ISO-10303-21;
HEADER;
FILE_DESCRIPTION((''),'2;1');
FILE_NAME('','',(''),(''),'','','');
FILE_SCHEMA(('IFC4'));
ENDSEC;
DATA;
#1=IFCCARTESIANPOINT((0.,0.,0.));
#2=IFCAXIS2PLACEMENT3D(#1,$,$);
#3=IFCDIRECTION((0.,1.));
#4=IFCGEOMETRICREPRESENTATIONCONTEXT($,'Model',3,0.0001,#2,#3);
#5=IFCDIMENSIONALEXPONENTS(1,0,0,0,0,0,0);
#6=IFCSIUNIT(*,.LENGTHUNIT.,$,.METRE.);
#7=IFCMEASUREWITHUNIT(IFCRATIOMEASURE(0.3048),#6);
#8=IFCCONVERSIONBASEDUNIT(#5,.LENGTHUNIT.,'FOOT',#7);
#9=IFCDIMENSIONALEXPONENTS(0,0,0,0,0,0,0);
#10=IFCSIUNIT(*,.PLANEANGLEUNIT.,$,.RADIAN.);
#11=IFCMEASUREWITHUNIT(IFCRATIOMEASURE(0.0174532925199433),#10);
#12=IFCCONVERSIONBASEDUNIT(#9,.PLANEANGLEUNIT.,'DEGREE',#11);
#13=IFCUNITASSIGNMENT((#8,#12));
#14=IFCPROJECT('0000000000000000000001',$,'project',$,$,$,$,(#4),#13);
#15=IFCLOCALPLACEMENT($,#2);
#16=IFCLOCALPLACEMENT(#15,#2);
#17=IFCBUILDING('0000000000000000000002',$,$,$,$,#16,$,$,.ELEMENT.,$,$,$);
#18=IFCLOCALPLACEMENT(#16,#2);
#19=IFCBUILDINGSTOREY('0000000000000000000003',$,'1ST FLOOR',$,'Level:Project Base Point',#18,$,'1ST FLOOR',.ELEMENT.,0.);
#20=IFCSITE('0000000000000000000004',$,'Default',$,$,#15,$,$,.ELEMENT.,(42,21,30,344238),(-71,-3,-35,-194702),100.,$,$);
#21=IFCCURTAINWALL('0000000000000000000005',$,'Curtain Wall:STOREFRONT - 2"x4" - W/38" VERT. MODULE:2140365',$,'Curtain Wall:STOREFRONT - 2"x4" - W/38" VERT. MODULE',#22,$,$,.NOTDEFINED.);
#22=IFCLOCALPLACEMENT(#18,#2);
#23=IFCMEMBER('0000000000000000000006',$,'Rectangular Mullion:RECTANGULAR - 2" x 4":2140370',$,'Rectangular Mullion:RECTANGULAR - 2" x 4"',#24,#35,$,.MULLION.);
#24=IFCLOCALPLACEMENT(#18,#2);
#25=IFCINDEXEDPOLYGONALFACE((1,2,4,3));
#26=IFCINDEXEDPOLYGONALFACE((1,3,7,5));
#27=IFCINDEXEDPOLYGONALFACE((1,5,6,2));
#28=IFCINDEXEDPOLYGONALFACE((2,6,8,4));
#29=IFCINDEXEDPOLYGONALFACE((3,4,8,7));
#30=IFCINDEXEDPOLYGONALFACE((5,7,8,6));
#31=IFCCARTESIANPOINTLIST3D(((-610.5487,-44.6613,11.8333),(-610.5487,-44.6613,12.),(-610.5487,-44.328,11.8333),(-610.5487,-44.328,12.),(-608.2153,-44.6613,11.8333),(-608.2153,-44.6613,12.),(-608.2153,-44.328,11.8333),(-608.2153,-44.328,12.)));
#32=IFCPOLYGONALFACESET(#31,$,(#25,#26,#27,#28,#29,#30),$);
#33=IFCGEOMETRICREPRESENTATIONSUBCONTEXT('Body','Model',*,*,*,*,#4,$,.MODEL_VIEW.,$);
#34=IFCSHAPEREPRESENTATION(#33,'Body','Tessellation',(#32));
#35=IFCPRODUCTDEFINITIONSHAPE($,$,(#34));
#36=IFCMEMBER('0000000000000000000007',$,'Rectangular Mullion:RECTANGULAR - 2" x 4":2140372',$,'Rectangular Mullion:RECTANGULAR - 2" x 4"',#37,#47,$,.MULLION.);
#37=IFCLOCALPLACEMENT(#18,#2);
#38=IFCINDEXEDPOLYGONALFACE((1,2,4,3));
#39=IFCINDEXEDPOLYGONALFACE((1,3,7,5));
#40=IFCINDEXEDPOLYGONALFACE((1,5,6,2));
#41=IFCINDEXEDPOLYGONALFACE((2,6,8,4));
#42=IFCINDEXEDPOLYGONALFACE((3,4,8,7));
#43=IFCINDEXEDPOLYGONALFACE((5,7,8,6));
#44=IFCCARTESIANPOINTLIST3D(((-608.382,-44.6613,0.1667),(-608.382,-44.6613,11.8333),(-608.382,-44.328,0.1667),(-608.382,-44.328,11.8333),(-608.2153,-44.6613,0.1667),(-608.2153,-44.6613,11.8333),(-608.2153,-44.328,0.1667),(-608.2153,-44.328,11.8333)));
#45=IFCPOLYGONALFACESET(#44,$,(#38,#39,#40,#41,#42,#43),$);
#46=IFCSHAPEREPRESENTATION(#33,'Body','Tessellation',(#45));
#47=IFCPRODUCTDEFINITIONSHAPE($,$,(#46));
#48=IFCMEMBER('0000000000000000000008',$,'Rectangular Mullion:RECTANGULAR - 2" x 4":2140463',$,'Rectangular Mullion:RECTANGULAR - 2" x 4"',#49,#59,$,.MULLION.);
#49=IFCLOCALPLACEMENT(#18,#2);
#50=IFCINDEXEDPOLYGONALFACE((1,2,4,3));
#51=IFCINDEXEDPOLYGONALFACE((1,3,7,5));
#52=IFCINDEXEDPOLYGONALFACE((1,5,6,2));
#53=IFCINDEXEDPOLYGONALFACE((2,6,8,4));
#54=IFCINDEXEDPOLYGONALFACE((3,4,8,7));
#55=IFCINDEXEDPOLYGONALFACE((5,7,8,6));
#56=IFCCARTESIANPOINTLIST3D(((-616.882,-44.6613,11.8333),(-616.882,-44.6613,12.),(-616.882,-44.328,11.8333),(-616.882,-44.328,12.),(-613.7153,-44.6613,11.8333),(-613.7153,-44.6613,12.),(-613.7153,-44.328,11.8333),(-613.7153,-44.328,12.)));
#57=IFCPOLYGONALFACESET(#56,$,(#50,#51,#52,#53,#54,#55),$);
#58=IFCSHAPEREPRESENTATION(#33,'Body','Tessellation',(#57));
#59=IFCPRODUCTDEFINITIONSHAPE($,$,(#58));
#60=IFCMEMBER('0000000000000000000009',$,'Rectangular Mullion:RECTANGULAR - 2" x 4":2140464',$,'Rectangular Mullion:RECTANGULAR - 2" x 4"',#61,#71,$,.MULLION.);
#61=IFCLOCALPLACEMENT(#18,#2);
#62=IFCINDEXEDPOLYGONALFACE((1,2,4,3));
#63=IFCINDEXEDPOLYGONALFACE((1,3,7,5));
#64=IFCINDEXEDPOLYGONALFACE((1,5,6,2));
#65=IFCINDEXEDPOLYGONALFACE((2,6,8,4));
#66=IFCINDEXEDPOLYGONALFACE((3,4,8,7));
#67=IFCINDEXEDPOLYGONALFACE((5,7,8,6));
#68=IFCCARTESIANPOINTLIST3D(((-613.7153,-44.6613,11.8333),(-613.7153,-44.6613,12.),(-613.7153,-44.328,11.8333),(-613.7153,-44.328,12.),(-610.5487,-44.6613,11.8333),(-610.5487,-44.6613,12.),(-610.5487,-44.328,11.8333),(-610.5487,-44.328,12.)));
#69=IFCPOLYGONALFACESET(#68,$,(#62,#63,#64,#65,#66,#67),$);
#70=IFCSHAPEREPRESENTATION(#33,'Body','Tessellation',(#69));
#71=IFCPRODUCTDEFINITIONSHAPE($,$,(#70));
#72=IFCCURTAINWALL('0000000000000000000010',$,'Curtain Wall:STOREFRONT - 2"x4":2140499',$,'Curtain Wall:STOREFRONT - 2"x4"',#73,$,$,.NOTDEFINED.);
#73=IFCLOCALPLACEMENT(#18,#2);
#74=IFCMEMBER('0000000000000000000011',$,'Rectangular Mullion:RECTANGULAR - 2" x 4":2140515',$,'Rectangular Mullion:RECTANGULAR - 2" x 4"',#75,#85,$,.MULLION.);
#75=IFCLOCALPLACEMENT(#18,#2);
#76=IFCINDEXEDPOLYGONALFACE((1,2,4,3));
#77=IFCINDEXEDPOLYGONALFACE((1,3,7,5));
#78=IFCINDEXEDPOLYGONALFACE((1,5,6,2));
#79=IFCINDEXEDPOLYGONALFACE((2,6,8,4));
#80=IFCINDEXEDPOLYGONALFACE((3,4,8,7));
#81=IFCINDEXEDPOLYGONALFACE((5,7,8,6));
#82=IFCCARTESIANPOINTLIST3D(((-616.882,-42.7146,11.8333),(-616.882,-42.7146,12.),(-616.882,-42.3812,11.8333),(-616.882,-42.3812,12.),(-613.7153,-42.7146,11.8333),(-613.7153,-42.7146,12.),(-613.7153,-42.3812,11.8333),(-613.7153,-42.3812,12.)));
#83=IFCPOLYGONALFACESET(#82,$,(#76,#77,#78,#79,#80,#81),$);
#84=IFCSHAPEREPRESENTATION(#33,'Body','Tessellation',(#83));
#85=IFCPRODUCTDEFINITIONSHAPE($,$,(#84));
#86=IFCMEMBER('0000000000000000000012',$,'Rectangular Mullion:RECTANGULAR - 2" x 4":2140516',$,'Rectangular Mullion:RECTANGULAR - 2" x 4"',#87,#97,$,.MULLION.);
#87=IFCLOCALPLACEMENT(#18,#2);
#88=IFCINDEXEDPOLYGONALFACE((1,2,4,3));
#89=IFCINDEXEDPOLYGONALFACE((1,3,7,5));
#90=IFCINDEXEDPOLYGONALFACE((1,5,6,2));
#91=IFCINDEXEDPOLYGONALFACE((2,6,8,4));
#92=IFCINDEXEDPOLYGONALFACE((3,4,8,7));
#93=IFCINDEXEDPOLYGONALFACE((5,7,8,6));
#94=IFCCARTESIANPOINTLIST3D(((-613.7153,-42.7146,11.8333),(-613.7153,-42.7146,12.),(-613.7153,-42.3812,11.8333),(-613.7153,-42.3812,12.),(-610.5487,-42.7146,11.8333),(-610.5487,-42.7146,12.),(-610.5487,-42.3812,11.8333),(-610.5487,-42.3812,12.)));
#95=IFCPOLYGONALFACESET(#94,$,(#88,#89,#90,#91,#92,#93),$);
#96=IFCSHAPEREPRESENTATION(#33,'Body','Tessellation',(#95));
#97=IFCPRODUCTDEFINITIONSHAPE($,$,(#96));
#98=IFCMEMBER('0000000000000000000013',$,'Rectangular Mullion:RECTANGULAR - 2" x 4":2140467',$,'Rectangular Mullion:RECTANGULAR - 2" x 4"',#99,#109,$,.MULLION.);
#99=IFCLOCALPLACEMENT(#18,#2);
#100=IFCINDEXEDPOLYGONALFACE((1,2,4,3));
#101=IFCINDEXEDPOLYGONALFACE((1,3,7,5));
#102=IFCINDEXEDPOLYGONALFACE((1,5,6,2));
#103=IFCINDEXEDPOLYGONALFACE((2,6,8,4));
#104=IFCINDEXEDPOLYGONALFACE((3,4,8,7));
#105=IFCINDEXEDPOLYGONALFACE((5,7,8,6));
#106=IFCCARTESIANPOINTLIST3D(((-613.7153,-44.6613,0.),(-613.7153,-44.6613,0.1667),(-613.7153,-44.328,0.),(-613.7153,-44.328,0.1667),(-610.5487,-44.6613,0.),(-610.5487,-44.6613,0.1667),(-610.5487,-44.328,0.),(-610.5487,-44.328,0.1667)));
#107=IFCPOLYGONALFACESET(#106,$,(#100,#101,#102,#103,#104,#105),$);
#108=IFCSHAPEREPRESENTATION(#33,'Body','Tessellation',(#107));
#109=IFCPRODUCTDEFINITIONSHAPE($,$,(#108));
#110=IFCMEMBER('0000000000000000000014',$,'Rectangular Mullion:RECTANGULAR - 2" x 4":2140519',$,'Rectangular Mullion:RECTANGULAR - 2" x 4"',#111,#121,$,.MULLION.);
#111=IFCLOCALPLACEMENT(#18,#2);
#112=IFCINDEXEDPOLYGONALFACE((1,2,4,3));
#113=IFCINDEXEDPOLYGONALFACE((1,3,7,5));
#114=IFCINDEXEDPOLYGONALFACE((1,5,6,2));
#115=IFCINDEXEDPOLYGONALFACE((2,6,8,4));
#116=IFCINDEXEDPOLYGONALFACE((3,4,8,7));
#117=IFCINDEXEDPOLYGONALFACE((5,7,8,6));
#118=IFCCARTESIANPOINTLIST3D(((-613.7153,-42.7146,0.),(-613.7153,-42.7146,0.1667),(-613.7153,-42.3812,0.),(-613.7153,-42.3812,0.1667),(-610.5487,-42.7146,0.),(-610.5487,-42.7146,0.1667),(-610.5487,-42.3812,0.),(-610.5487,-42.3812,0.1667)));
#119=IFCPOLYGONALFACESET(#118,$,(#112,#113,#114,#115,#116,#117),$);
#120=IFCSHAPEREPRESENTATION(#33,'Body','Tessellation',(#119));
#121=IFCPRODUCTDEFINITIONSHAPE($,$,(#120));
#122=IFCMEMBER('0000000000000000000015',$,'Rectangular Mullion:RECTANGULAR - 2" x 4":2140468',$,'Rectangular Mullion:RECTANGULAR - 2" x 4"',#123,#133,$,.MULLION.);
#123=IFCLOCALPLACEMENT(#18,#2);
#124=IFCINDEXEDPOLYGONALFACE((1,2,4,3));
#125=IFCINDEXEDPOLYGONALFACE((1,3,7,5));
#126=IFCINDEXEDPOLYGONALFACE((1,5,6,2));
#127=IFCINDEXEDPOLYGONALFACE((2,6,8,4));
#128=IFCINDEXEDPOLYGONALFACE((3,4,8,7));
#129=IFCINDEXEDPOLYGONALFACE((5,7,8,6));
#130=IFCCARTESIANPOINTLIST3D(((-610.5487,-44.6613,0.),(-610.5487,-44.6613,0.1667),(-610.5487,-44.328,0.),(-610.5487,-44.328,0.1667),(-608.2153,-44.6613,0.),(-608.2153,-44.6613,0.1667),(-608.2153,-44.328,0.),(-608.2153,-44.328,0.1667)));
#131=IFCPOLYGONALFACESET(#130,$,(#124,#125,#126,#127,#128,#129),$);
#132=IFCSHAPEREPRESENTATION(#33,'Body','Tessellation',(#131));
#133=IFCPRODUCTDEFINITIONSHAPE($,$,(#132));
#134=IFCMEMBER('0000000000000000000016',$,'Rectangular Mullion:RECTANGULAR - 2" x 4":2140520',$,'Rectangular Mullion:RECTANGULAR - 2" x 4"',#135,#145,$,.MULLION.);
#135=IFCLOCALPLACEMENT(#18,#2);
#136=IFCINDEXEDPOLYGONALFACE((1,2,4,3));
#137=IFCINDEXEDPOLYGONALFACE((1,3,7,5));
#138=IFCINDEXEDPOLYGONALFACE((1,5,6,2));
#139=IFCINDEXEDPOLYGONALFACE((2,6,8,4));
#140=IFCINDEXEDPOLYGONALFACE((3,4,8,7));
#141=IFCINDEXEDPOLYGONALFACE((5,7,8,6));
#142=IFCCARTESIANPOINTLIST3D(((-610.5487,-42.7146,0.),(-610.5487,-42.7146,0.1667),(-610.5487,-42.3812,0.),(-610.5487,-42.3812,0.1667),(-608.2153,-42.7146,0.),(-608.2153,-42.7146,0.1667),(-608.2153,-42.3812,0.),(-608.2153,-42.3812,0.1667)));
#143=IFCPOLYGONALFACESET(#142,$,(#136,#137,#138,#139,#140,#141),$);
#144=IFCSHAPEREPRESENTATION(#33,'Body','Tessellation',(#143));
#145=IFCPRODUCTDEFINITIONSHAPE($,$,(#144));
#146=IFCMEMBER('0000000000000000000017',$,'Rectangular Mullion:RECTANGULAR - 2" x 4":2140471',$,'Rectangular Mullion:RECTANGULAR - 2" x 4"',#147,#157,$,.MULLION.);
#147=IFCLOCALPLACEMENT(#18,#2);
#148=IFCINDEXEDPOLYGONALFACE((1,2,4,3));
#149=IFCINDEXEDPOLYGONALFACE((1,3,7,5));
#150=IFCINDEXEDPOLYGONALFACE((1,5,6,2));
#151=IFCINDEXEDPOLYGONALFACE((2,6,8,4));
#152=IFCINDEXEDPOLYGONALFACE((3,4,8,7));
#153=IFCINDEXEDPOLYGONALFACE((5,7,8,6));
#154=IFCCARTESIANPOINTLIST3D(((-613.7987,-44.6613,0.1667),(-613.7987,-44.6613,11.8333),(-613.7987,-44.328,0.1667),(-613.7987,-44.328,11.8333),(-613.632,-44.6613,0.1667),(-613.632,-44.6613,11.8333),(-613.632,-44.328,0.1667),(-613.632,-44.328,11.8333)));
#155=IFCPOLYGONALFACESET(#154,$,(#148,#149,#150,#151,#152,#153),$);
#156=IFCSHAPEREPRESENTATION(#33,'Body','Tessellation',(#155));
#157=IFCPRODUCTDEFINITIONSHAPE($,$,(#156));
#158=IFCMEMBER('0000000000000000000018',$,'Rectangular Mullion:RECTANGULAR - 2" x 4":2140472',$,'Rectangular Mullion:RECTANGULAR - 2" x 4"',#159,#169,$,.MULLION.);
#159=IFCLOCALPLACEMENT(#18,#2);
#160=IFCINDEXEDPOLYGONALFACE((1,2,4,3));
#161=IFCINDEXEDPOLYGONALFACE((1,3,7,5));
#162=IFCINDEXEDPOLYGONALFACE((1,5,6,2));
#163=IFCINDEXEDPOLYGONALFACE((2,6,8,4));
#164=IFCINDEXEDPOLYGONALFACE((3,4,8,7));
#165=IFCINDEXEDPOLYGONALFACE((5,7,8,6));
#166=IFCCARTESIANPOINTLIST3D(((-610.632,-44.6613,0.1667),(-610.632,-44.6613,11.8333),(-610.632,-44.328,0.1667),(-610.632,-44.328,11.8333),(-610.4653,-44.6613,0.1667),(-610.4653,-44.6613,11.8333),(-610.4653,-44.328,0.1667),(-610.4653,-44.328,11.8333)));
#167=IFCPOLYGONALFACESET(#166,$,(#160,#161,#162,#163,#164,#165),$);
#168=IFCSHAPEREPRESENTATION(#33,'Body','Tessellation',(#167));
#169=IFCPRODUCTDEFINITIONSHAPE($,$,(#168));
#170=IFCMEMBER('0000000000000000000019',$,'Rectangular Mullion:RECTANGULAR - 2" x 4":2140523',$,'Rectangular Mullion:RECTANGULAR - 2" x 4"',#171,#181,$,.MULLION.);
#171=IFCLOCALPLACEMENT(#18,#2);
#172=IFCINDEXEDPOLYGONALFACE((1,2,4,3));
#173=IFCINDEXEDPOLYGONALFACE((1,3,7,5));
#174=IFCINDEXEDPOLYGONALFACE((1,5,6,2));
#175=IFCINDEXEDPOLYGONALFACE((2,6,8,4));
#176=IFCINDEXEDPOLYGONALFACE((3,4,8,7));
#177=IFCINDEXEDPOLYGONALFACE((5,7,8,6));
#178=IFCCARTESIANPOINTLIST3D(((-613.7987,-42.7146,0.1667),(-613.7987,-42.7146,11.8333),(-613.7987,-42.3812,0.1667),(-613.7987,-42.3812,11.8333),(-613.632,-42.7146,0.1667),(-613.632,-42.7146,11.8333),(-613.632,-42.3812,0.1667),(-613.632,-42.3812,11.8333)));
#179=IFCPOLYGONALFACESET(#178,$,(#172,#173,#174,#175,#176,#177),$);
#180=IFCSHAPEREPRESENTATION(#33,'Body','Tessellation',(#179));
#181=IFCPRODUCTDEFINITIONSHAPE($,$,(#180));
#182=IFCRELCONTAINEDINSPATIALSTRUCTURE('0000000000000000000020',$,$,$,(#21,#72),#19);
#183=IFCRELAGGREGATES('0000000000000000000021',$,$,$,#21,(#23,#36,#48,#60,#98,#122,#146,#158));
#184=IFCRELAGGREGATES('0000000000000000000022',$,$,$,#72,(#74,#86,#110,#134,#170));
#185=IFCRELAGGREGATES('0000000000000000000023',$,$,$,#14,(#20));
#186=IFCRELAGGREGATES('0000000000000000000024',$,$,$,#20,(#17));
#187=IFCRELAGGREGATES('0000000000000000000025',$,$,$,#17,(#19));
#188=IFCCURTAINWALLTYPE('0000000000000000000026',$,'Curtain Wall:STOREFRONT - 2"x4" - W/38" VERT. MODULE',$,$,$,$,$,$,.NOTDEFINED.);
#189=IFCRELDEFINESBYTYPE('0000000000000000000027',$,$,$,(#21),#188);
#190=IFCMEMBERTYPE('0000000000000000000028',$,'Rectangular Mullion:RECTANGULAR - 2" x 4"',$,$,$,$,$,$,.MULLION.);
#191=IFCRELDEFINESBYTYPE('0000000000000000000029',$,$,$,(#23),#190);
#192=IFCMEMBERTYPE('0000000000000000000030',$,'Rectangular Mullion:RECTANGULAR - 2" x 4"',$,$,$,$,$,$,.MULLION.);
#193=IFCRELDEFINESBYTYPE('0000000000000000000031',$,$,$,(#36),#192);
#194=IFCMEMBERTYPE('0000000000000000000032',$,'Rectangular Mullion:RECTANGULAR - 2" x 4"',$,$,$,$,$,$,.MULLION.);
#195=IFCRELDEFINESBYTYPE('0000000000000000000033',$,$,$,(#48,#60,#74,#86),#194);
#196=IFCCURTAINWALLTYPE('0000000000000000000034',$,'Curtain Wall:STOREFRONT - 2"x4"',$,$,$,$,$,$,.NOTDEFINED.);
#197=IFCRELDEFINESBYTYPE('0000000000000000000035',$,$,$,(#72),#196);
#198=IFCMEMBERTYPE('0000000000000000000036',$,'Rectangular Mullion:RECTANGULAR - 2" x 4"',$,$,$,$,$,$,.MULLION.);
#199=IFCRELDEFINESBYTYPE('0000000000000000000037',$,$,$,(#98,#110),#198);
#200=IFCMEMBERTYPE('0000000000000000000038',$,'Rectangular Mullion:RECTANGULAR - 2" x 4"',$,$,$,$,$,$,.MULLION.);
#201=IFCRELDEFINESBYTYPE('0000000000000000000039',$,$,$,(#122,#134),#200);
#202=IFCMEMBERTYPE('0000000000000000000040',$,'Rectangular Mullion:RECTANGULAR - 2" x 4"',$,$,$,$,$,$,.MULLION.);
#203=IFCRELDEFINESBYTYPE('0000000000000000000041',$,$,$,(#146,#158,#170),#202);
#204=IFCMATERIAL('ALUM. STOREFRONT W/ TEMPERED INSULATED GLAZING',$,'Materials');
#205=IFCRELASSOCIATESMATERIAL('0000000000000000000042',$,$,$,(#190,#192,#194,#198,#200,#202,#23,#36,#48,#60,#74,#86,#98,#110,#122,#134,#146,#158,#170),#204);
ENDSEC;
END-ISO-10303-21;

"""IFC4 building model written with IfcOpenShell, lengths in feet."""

from ifc_helpers import new_model, entity, si_unit, converted_unit, direction, frame, origin, origin_2d_with_axis, place, context, subcontext, project, spatial, rectangle, extrude, source, transform, mapped, material, material_profile, profile_set, profile_usage, type_object, type_shapes, element, aggregate, save


model = new_model("IFC4")

# Units and contexts
model_context = context("Model", 3, precision=0.0001, world=origin(), true_north=direction((0.0, 1.0)))
body_context = subcontext(model_context, "Body", "Model", "MODEL_VIEW")
ifc_project = project(units=[converted_unit("LENGTHUNIT", "FOOT", entity("IfcRatioMeasure", 0.3048), si_unit("LENGTHUNIT", "METRE"), dimensions=[1, 0, 0, 0, 0, 0, 0]), converted_unit("PLANEANGLEUNIT", "DEGREE", entity("IfcRatioMeasure", 0.0174532925199433), si_unit("PLANEANGLEUNIT", "RADIAN"), dimensions=[0, 0, 0, 0, 0, 0, 0])], contexts=[model_context])

# Site, building, storey
site_placement = place(None, origin())
site = spatial("IfcSite", under=ifc_project, at=site_placement, Name="Default", CompositionType="ELEMENT", RefLatitude=(42, 21, 30, 344238), RefLongitude=(-71, -3, -35, -194702), RefElevation=100.0)
building_placement = place(site_placement, origin())
building = spatial("IfcBuilding", under=site, at=building_placement, CompositionType="ELEMENT")
storey_placement = place(building_placement, origin())
storey = spatial("IfcBuildingStorey", under=building, at=storey_placement, Name="1ST FLOOR", ObjectType="Level:Project Base Point", LongName="1ST FLOOR", CompositionType="ELEMENT", Elevation=0.0)

# Curtain walls, members
curtain_wall_type_1 = type_object("IfcCurtainWallType", Name="Curtain Wall:STOREFRONT - 2\"x4\" - W/38\" VERT. MODULE", PredefinedType="NOTDEFINED")
curtain_wall_1_placement = place(storey_placement, origin())
curtain_wall_1 = element("IfcCurtainWall", 1, at=curtain_wall_1_placement, inside=storey, type_object=curtain_wall_type_1, Name="Curtain Wall:STOREFRONT - 2\"x4\" - W/38\" VERT. MODULE:2140365", ObjectType="Curtain Wall:STOREFRONT - 2\"x4\" - W/38\" VERT. MODULE", PredefinedType="NOTDEFINED")
ifc_material_1 = material(Name="ALUM. STOREFRONT W/ TEMPERED INSULATED GLAZING", Category="Materials")
ifc_material_profile_1 = material_profile(ifc_material_1, rectangle(XDim=0.3333, YDim=0.1667, at=origin_2d_with_axis()), Name="RECTANGULAR - 2\" x 4\"")
ifc_profile_set_1 = profile_set([ifc_material_profile_1], Name="RECTANGULAR - 2\" x 4\"")
ifc_profile_usage_1 = profile_usage(ifc_profile_set_1)
member_type_1 = type_object("IfcMemberType", Name="Rectangular Mullion:RECTANGULAR - 2\" x 4\"", PredefinedType="MULLION", material=ifc_profile_set_1)
shared_shape_1 = source(origin(), body_context, "Body", "SweptSolid", [
    extrude(rectangle(XDim=0.3333, YDim=0.1667, at=origin_2d_with_axis()), frame((-0.0833, 0.0, -2.3333), z_axis=(0.0, 0.0, 1.0), x_axis=(0.0, -1.0, 0.0)), (0.0, 0.0, 1.0), 2.3333),
])
type_shapes(member_type_1, [shared_shape_1])
member_1_placement = place(storey_placement, frame((-608.2153, -44.4946, 12.0), z_axis=(1.0, 0.0, 0.0), x_axis=(0.0, 0.0, 1.0)))
member_1 = element("IfcMember", 2, at=member_1_placement, type_object=member_type_1, material=ifc_profile_usage_1, Name="Rectangular Mullion:RECTANGULAR - 2\" x 4\":2140370", ObjectType="Rectangular Mullion:RECTANGULAR - 2\" x 4\"", PredefinedType="MULLION", context=body_context, shape_type="MappedRepresentation", body=[
    mapped(shared_shape_1, transform((0.0, 0.0, 0.0), scale=1.0)),
])
ifc_profile_usage_2 = profile_usage(ifc_profile_set_1)
member_type_2 = type_object("IfcMemberType", Name="Rectangular Mullion:RECTANGULAR - 2\" x 4\"", PredefinedType="MULLION", material=ifc_profile_set_1)
shared_shape_2 = source(origin(), body_context, "Body", "SweptSolid", [
    extrude(rectangle(XDim=0.3333, YDim=0.1667, at=origin_2d_with_axis()), frame((-0.0833, 0.0, -11.6667), z_axis=(0.0, 0.0, 1.0), x_axis=(0.0, -1.0, 0.0)), (0.0, 0.0, 1.0), 11.6667),
])
type_shapes(member_type_2, [shared_shape_2])
member_2_placement = place(storey_placement, frame((-608.2153, -44.4946, 0.1667), z_axis=(0.0, 0.0, -1.0), x_axis=(1.0, 0.0, 0.0)))
member_2 = element("IfcMember", 3, at=member_2_placement, type_object=member_type_2, material=ifc_profile_usage_2, Name="Rectangular Mullion:RECTANGULAR - 2\" x 4\":2140372", ObjectType="Rectangular Mullion:RECTANGULAR - 2\" x 4\"", PredefinedType="MULLION", context=body_context, shape_type="MappedRepresentation", body=[
    mapped(shared_shape_2, transform((0.0, 0.0, 0.0), scale=1.0)),
])
ifc_profile_usage_3 = profile_usage(ifc_profile_set_1)
member_type_3 = type_object("IfcMemberType", Name="Rectangular Mullion:RECTANGULAR - 2\" x 4\"", PredefinedType="MULLION", material=ifc_profile_set_1)
shared_shape_3 = source(origin(), body_context, "Body", "SweptSolid", [
    extrude(rectangle(XDim=0.3333, YDim=0.1667, at=origin_2d_with_axis()), frame((-0.0833, 0.0, -3.1667), z_axis=(0.0, 0.0, 1.0), x_axis=(0.0, -1.0, 0.0)), (0.0, 0.0, 1.0), 3.1667),
])
type_shapes(member_type_3, [shared_shape_3])
member_3_placement = place(storey_placement, frame((-613.7153, -44.4946, 12.0), z_axis=(1.0, 0.0, 0.0), x_axis=(0.0, 0.0, 1.0)))
member_3 = element("IfcMember", 4, at=member_3_placement, type_object=member_type_3, material=ifc_profile_usage_3, Name="Rectangular Mullion:RECTANGULAR - 2\" x 4\":2140463", ObjectType="Rectangular Mullion:RECTANGULAR - 2\" x 4\"", PredefinedType="MULLION", context=body_context, shape_type="MappedRepresentation", body=[
    mapped(shared_shape_3, transform((0.0, 0.0, 0.0), scale=1.0)),
])
ifc_profile_usage_4 = profile_usage(ifc_profile_set_1)
member_4_placement = place(storey_placement, frame((-610.5487, -44.4946, 12.0), z_axis=(1.0, 0.0, 0.0), x_axis=(0.0, 0.0, 1.0)))
member_4 = element("IfcMember", 5, at=member_4_placement, type_object=member_type_3, material=ifc_profile_usage_4, Name="Rectangular Mullion:RECTANGULAR - 2\" x 4\":2140464", ObjectType="Rectangular Mullion:RECTANGULAR - 2\" x 4\"", PredefinedType="MULLION", context=body_context, shape_type="MappedRepresentation", body=[
    mapped(shared_shape_3, transform((0.0, 0.0, 0.0), scale=1.0)),
])
curtain_wall_type_2 = type_object("IfcCurtainWallType", Name="Curtain Wall:STOREFRONT - 2\"x4\"", PredefinedType="NOTDEFINED")
curtain_wall_2_placement = place(storey_placement, origin())
curtain_wall_2 = element("IfcCurtainWall", 6, at=curtain_wall_2_placement, inside=storey, type_object=curtain_wall_type_2, Name="Curtain Wall:STOREFRONT - 2\"x4\":2140499", ObjectType="Curtain Wall:STOREFRONT - 2\"x4\"", PredefinedType="NOTDEFINED")
ifc_profile_usage_5 = profile_usage(ifc_profile_set_1)
member_5_placement = place(storey_placement, frame((-613.7153, -42.5479, 12.0), z_axis=(1.0, 0.0, 0.0), x_axis=(0.0, 0.0, 1.0)))
member_5 = element("IfcMember", 7, at=member_5_placement, type_object=member_type_3, material=ifc_profile_usage_5, Name="Rectangular Mullion:RECTANGULAR - 2\" x 4\":2140515", ObjectType="Rectangular Mullion:RECTANGULAR - 2\" x 4\"", PredefinedType="MULLION", context=body_context, shape_type="MappedRepresentation", body=[
    mapped(shared_shape_3, transform((0.0, 0.0, 0.0), scale=1.0)),
])
ifc_profile_usage_6 = profile_usage(ifc_profile_set_1)
member_6_placement = place(storey_placement, frame((-610.5487, -42.5479, 12.0), z_axis=(1.0, 0.0, 0.0), x_axis=(0.0, 0.0, 1.0)))
member_6 = element("IfcMember", 8, at=member_6_placement, type_object=member_type_3, material=ifc_profile_usage_6, Name="Rectangular Mullion:RECTANGULAR - 2\" x 4\":2140516", ObjectType="Rectangular Mullion:RECTANGULAR - 2\" x 4\"", PredefinedType="MULLION", context=body_context, shape_type="MappedRepresentation", body=[
    mapped(shared_shape_3, transform((0.0, 0.0, 0.0), scale=1.0)),
])

# Members
ifc_profile_usage_7 = profile_usage(ifc_profile_set_1)
member_type_4 = type_object("IfcMemberType", Name="Rectangular Mullion:RECTANGULAR - 2\" x 4\"", PredefinedType="MULLION", material=ifc_profile_set_1)
shared_shape_4 = source(origin(), body_context, "Body", "SweptSolid", [
    extrude(rectangle(XDim=0.3333, YDim=0.1667, at=origin_2d_with_axis()), frame((-0.0833, 0.0, -3.1667), z_axis=(0.0, 0.0, 1.0), x_axis=(0.0, -1.0, 0.0)), (0.0, 0.0, 1.0), 3.1667),
])
type_shapes(member_type_4, [shared_shape_4])
member_7_placement = place(storey_placement, frame((-613.7153, -44.4946, 0.0), z_axis=(-1.0, 0.0, 0.0), x_axis=(0.0, 0.0, -1.0)))
member_7 = element("IfcMember", 9, at=member_7_placement, type_object=member_type_4, material=ifc_profile_usage_7, Name="Rectangular Mullion:RECTANGULAR - 2\" x 4\":2140467", ObjectType="Rectangular Mullion:RECTANGULAR - 2\" x 4\"", PredefinedType="MULLION", context=body_context, shape_type="MappedRepresentation", body=[
    mapped(shared_shape_4, transform((0.0, 0.0, 0.0), scale=1.0)),
])
ifc_profile_usage_8 = profile_usage(ifc_profile_set_1)
member_8_placement = place(storey_placement, frame((-613.7153, -42.5479, 0.0), z_axis=(-1.0, 0.0, 0.0), x_axis=(0.0, 0.0, -1.0)))
member_8 = element("IfcMember", 10, at=member_8_placement, type_object=member_type_4, material=ifc_profile_usage_8, Name="Rectangular Mullion:RECTANGULAR - 2\" x 4\":2140519", ObjectType="Rectangular Mullion:RECTANGULAR - 2\" x 4\"", PredefinedType="MULLION", context=body_context, shape_type="MappedRepresentation", body=[
    mapped(shared_shape_4, transform((0.0, 0.0, 0.0), scale=1.0)),
])
ifc_profile_usage_9 = profile_usage(ifc_profile_set_1)
member_type_5 = type_object("IfcMemberType", Name="Rectangular Mullion:RECTANGULAR - 2\" x 4\"", PredefinedType="MULLION", material=ifc_profile_set_1)
shared_shape_5 = source(origin(), body_context, "Body", "SweptSolid", [
    extrude(rectangle(XDim=0.3333, YDim=0.1667, at=origin_2d_with_axis()), frame((-0.0833, 0.0, -2.3333), z_axis=(0.0, 0.0, 1.0), x_axis=(0.0, -1.0, 0.0)), (0.0, 0.0, 1.0), 2.3333),
])
type_shapes(member_type_5, [shared_shape_5])
member_9_placement = place(storey_placement, frame((-610.5487, -44.4946, 0.0), z_axis=(-1.0, 0.0, 0.0), x_axis=(0.0, 0.0, -1.0)))
member_9 = element("IfcMember", 11, at=member_9_placement, type_object=member_type_5, material=ifc_profile_usage_9, Name="Rectangular Mullion:RECTANGULAR - 2\" x 4\":2140468", ObjectType="Rectangular Mullion:RECTANGULAR - 2\" x 4\"", PredefinedType="MULLION", context=body_context, shape_type="MappedRepresentation", body=[
    mapped(shared_shape_5, transform((0.0, 0.0, 0.0), scale=1.0)),
])
ifc_profile_usage_10 = profile_usage(ifc_profile_set_1)
member_10_placement = place(storey_placement, frame((-610.5487, -42.5479, 0.0), z_axis=(-1.0, 0.0, 0.0), x_axis=(0.0, 0.0, -1.0)))
member_10 = element("IfcMember", 12, at=member_10_placement, type_object=member_type_5, material=ifc_profile_usage_10, Name="Rectangular Mullion:RECTANGULAR - 2\" x 4\":2140520", ObjectType="Rectangular Mullion:RECTANGULAR - 2\" x 4\"", PredefinedType="MULLION", context=body_context, shape_type="MappedRepresentation", body=[
    mapped(shared_shape_5, transform((0.0, 0.0, 0.0), scale=1.0)),
])
ifc_profile_usage_11 = profile_usage(ifc_profile_set_1)
member_type_6 = type_object("IfcMemberType", Name="Rectangular Mullion:RECTANGULAR - 2\" x 4\"", PredefinedType="MULLION", material=ifc_profile_set_1)
shared_shape_6 = source(origin(), body_context, "Body", "SweptSolid", [
    extrude(rectangle(XDim=0.3333, YDim=0.1667, at=origin_2d_with_axis()), frame((0.0, 0.0, -11.6667), z_axis=(0.0, 0.0, 1.0), x_axis=(0.0, -1.0, 0.0)), (0.0, 0.0, 1.0), 11.6667),
])
type_shapes(member_type_6, [shared_shape_6])
member_11_placement = place(storey_placement, frame((-613.7153, -44.4946, 0.1667), z_axis=(0.0, 0.0, -1.0), x_axis=(1.0, 0.0, 0.0)))
member_11 = element("IfcMember", 13, at=member_11_placement, type_object=member_type_6, material=ifc_profile_usage_11, Name="Rectangular Mullion:RECTANGULAR - 2\" x 4\":2140471", ObjectType="Rectangular Mullion:RECTANGULAR - 2\" x 4\"", PredefinedType="MULLION", context=body_context, shape_type="MappedRepresentation", body=[
    mapped(shared_shape_6, transform((0.0, 0.0, 0.0), scale=1.0)),
])
ifc_profile_usage_12 = profile_usage(ifc_profile_set_1)
member_12_placement = place(storey_placement, frame((-610.5487, -44.4946, 0.1667), z_axis=(0.0, 0.0, -1.0), x_axis=(1.0, 0.0, 0.0)))
member_12 = element("IfcMember", 14, at=member_12_placement, type_object=member_type_6, material=ifc_profile_usage_12, Name="Rectangular Mullion:RECTANGULAR - 2\" x 4\":2140472", ObjectType="Rectangular Mullion:RECTANGULAR - 2\" x 4\"", PredefinedType="MULLION", context=body_context, shape_type="MappedRepresentation", body=[
    mapped(shared_shape_6, transform((0.0, 0.0, 0.0), scale=1.0)),
])
ifc_profile_usage_13 = profile_usage(ifc_profile_set_1)
member_13_placement = place(storey_placement, frame((-613.7153, -42.5479, 0.1667), z_axis=(0.0, 0.0, -1.0), x_axis=(1.0, 0.0, 0.0)))
member_13 = element("IfcMember", 15, at=member_13_placement, type_object=member_type_6, material=ifc_profile_usage_13, Name="Rectangular Mullion:RECTANGULAR - 2\" x 4\":2140523", ObjectType="Rectangular Mullion:RECTANGULAR - 2\" x 4\"", PredefinedType="MULLION", context=body_context, shape_type="MappedRepresentation", body=[
    mapped(shared_shape_6, transform((0.0, 0.0, 0.0), scale=1.0)),
])

aggregate(curtain_wall_1, [member_1, member_2, member_3, member_4, member_7, member_9, member_11, member_12])
aggregate(curtain_wall_2, [member_5, member_6, member_8, member_10, member_13])

save(model, "model.ifc")
